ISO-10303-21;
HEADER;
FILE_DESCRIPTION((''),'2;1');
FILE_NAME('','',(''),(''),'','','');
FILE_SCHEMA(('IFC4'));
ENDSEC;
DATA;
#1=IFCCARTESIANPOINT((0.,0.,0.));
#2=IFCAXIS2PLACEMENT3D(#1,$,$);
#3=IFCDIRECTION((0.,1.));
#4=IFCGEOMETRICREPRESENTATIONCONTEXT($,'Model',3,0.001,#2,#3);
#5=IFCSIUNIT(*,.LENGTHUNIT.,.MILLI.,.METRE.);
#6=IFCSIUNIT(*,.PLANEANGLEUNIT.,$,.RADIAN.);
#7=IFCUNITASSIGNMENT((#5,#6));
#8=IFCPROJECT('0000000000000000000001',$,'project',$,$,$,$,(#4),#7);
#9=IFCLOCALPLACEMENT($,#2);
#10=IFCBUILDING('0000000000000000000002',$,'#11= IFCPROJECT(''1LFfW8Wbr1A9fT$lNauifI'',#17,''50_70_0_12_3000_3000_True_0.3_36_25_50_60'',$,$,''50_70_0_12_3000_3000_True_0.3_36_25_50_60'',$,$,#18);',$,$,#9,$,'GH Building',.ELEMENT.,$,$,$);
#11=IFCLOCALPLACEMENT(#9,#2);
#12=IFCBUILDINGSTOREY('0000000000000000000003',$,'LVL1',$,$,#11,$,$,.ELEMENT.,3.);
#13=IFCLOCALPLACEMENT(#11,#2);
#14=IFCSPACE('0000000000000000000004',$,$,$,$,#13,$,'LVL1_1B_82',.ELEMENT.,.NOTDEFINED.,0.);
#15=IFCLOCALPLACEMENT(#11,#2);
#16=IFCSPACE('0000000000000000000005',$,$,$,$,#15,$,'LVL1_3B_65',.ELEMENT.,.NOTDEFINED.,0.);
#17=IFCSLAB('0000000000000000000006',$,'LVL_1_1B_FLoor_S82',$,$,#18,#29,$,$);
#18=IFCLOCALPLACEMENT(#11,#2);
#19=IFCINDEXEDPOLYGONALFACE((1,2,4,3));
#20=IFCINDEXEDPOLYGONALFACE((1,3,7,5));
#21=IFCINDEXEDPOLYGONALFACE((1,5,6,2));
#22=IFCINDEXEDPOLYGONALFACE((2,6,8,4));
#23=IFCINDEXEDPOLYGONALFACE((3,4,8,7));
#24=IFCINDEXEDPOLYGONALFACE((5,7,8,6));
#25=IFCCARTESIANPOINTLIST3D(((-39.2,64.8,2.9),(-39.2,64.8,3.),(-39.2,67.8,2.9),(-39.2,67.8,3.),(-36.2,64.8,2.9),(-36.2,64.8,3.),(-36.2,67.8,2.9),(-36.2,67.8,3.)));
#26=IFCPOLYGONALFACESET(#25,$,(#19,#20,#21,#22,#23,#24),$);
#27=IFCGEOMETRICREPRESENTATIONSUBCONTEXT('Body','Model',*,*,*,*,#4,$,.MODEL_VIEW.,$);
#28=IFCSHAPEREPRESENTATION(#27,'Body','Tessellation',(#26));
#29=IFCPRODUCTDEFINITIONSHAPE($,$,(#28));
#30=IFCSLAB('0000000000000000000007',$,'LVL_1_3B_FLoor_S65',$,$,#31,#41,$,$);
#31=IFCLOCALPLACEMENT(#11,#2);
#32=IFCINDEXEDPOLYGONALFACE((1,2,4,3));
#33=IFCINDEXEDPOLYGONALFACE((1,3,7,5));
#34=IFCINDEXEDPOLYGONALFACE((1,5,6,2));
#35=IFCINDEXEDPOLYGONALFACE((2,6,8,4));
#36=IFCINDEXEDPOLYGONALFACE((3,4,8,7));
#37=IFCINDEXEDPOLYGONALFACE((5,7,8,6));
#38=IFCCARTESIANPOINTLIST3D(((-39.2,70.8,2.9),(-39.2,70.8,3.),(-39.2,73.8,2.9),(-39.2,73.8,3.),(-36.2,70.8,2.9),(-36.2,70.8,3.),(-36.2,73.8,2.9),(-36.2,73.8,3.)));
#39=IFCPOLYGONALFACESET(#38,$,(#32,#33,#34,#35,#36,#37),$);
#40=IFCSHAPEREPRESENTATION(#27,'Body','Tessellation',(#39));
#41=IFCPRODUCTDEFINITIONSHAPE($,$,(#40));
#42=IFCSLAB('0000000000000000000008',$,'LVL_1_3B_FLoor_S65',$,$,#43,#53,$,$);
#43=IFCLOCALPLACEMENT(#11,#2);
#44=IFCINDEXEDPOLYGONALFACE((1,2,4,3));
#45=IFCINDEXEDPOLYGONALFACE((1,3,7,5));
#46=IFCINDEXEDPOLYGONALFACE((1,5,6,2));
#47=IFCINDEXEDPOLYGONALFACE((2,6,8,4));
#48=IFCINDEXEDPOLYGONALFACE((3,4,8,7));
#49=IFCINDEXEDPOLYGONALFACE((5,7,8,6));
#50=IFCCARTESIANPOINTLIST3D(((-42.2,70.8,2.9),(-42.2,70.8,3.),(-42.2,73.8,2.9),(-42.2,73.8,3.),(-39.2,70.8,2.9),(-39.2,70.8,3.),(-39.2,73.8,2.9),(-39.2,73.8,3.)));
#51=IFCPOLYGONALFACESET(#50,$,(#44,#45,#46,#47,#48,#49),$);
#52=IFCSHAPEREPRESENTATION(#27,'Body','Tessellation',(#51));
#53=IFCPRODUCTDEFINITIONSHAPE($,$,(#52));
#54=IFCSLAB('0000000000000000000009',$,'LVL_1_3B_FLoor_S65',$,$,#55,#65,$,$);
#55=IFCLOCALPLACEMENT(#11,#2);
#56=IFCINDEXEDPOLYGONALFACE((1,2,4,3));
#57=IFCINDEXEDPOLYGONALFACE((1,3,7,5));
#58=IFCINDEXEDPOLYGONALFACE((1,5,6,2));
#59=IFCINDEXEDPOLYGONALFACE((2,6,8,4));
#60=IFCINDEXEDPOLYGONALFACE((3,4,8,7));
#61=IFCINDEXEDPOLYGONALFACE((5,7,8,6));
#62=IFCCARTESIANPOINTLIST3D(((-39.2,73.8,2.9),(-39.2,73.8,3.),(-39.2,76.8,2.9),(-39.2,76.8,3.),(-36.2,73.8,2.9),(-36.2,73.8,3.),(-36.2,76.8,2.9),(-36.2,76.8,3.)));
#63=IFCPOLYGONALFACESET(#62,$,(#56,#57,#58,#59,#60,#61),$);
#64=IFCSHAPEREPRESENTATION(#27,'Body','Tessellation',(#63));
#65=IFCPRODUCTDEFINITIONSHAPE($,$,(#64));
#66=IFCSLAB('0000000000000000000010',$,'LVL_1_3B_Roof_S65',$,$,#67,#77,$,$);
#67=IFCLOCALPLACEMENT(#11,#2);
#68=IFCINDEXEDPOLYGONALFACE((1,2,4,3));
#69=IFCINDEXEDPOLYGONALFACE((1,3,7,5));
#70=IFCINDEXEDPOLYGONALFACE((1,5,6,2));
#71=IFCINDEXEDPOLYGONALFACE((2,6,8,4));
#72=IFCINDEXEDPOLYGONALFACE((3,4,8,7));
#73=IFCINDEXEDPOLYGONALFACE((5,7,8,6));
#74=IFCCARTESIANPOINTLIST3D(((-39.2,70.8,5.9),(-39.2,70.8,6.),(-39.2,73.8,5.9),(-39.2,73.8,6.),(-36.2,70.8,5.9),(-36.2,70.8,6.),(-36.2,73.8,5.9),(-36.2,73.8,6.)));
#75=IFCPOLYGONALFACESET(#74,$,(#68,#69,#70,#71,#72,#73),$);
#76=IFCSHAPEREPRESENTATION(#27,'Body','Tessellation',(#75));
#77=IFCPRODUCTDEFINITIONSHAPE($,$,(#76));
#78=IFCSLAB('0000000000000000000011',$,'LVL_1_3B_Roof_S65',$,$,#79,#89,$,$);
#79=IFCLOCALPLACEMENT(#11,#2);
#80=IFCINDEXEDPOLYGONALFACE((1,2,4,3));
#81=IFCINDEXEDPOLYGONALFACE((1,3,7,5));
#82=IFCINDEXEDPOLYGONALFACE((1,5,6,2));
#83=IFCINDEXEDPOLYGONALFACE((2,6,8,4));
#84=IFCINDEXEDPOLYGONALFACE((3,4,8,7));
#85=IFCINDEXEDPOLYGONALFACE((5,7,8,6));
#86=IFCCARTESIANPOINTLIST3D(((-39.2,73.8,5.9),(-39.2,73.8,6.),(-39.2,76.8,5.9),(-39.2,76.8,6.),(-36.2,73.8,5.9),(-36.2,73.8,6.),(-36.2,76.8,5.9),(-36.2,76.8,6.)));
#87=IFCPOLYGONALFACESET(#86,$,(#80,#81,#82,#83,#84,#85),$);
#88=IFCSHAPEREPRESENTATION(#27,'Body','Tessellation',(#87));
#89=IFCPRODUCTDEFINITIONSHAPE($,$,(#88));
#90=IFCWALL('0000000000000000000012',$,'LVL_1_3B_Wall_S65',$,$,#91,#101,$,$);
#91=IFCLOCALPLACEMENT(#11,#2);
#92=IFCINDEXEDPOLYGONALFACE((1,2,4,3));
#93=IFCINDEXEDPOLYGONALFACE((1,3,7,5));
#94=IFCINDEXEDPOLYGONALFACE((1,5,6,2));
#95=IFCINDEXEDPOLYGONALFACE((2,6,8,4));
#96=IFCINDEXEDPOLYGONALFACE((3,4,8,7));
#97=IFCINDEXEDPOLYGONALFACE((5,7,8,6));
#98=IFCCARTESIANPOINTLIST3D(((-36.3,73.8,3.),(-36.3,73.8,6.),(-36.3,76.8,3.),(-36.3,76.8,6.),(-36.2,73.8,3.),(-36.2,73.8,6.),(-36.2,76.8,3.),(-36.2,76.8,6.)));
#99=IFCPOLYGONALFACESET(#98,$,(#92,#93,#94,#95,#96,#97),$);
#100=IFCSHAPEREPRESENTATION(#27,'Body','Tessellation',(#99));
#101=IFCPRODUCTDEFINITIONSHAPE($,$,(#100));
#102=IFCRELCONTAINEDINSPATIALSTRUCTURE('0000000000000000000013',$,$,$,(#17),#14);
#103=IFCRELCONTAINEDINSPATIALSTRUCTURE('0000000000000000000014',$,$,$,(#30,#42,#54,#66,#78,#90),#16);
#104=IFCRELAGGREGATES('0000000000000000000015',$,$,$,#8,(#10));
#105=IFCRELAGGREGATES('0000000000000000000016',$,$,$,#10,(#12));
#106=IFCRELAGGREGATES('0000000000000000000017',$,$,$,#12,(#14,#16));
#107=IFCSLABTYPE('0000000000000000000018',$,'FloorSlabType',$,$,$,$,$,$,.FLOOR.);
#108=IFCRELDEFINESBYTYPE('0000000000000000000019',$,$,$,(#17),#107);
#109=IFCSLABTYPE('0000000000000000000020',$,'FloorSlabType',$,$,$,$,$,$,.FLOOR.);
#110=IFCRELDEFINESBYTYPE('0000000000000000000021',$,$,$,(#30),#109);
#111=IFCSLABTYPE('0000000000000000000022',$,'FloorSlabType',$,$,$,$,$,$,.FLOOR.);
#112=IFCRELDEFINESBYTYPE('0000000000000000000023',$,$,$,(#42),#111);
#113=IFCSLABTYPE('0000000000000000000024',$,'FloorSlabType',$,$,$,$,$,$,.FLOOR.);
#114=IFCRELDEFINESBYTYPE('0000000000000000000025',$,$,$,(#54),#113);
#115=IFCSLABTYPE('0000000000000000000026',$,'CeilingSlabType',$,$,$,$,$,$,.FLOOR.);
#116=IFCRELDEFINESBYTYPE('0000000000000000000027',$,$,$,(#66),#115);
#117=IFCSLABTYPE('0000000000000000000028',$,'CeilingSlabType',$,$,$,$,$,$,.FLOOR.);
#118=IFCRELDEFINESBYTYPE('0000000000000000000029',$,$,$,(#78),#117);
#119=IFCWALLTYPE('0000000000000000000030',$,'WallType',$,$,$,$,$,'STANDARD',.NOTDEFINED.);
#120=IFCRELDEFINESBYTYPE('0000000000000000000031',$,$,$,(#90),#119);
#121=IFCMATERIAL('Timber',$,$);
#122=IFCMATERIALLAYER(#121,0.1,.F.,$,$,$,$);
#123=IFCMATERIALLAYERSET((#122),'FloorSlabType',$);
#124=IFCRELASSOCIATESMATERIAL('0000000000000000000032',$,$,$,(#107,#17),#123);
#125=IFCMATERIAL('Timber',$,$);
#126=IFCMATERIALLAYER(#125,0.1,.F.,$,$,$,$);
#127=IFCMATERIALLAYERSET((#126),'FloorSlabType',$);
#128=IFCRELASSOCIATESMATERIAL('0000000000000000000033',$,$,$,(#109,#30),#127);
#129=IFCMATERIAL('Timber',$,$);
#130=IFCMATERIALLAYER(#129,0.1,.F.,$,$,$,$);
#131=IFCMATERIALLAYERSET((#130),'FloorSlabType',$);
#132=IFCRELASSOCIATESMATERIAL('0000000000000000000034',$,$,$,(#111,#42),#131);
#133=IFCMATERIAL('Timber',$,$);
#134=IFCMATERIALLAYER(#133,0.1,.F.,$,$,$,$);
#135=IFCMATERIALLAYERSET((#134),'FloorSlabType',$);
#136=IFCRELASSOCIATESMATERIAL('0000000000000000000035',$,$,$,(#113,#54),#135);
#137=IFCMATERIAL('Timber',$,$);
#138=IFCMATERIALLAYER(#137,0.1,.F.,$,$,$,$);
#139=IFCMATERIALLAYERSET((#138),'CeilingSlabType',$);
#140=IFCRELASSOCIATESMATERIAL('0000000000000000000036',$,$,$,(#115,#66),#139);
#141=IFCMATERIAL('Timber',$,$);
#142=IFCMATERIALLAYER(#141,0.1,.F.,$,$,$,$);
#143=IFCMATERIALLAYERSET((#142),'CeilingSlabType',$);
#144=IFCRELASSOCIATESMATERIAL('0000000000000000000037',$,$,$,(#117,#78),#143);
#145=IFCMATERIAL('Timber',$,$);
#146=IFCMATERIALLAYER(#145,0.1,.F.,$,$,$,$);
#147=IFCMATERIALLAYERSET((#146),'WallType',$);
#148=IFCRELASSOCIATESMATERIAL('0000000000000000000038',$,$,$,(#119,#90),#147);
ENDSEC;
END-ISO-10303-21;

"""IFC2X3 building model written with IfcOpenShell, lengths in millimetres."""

from ifc_helpers import new_model, si_unit, direction, frame, frame_2d, origin, place, context, subcontext, project, spatial, rectangle, extrude, material, layer, layer_set, layer_usage, type_object, element, save


model = new_model("IFC2X3")

# Units and contexts
model_context = context("Model", 3, precision=0.001, world=origin(), true_north=direction((0.0, 1.0)))
body_context = subcontext(model_context, "Body", "Model", "MODEL_VIEW")
ifc_project = project(units=[si_unit("LENGTHUNIT", "METRE", prefix="MILLI"), si_unit("PLANEANGLEUNIT", "RADIAN")], contexts=[model_context])

# Building, storey
building_placement = place(None, origin())
building = spatial("IfcBuilding", under=ifc_project, at=building_placement, Name="#11= IFCPROJECT('1LFfW8Wbr1A9fT$lNauifI',#17,'50_70_0_12_3000_3000_True_0.3_36_25_50_60',$,$,'50_70_0_12_3000_3000_True_0.3_36_25_50_60',$,$,#18);", LongName="GH Building", CompositionType="ELEMENT")
storey_placement = place(building_placement, origin())
storey = spatial("IfcBuildingStorey", under=building, at=storey_placement, Name="LVL1", CompositionType="ELEMENT", Elevation=3.0)

# Shared definitions
space_1_placement = place(storey_placement, origin())
space_1 = spatial("IfcSpace", under=storey, at=space_1_placement, LongName="LVL1_1B_82", CompositionType="ELEMENT", InteriorOrExteriorSpace="NOTDEFINED", ElevationWithFlooring=0.0)

# Slab
ifc_material_1 = material(Name="Timber")
ifc_layer_1 = layer(ifc_material_1, 0.1, ventilated=False)
ifc_layer_set_1 = layer_set([ifc_layer_1], Name="FloorSlabType")
ifc_layer_usage_1 = layer_usage(ifc_layer_set_1, "AXIS3", "NEGATIVE", -0.1)
slab_type_1 = type_object("IfcSlabType", Name="FloorSlabType", PredefinedType="FLOOR", material=ifc_layer_set_1)
slab_1_placement = place(space_1_placement, frame((-36.2, 67.8, 2.9), z_axis=(0.0, 0.0, 1.0), x_axis=(-1.0, 0.0, 0.0)))
element("IfcSlab", 1, at=slab_1_placement, inside=space_1, type_object=slab_type_1, material=ifc_layer_usage_1, Name="LVL_1_1B_FLoor_S82", context=body_context, shape_type="SweptSolid", body=[
    extrude(rectangle(XDim=3.0, YDim=3.0, at=frame_2d((1.5, 1.5))), origin(), (0.0, 0.0, 1.0), 0.1),
])

# Shared definitions
space_2_placement = place(storey_placement, origin())
space_2 = spatial("IfcSpace", under=storey, at=space_2_placement, LongName="LVL1_3B_65", CompositionType="ELEMENT", InteriorOrExteriorSpace="NOTDEFINED", ElevationWithFlooring=0.0)

# Slabs
ifc_material_2 = material(Name="Timber")
ifc_layer_2 = layer(ifc_material_2, 0.1, ventilated=False)
ifc_layer_set_2 = layer_set([ifc_layer_2], Name="FloorSlabType")
ifc_layer_usage_2 = layer_usage(ifc_layer_set_2, "AXIS3", "NEGATIVE", -0.1)
slab_type_2 = type_object("IfcSlabType", Name="FloorSlabType", PredefinedType="FLOOR", material=ifc_layer_set_2)
slab_2_placement = place(space_2_placement, frame((-36.2, 73.8, 2.9), z_axis=(0.0, 0.0, 1.0), x_axis=(-1.0, 0.0, 0.0)))
element("IfcSlab", 2, at=slab_2_placement, inside=space_2, type_object=slab_type_2, material=ifc_layer_usage_2, Name="LVL_1_3B_FLoor_S65", context=body_context, shape_type="SweptSolid", body=[
    extrude(rectangle(XDim=3.0, YDim=3.0, at=frame_2d((1.5, 1.5))), origin(), (0.0, 0.0, 1.0), 0.1),
])
ifc_material_3 = material(Name="Timber")
ifc_layer_3 = layer(ifc_material_3, 0.1, ventilated=False)
ifc_layer_set_3 = layer_set([ifc_layer_3], Name="FloorSlabType")
ifc_layer_usage_3 = layer_usage(ifc_layer_set_3, "AXIS3", "NEGATIVE", -0.1)
slab_type_3 = type_object("IfcSlabType", Name="FloorSlabType", PredefinedType="FLOOR", material=ifc_layer_set_3)
slab_3_placement = place(space_2_placement, frame((-39.2, 73.8, 2.9), z_axis=(0.0, 0.0, 1.0), x_axis=(-1.0, 0.0, 0.0)))
element("IfcSlab", 3, at=slab_3_placement, inside=space_2, type_object=slab_type_3, material=ifc_layer_usage_3, Name="LVL_1_3B_FLoor_S65", context=body_context, shape_type="SweptSolid", body=[
    extrude(rectangle(XDim=3.0, YDim=3.0, at=frame_2d((1.5, 1.5))), origin(), (0.0, 0.0, 1.0), 0.1),
])
ifc_material_4 = material(Name="Timber")
ifc_layer_4 = layer(ifc_material_4, 0.1, ventilated=False)
ifc_layer_set_4 = layer_set([ifc_layer_4], Name="FloorSlabType")
ifc_layer_usage_4 = layer_usage(ifc_layer_set_4, "AXIS3", "NEGATIVE", -0.1)
slab_type_4 = type_object("IfcSlabType", Name="FloorSlabType", PredefinedType="FLOOR", material=ifc_layer_set_4)
slab_4_placement = place(space_2_placement, frame((-36.2, 76.8, 2.9), z_axis=(0.0, 0.0, 1.0), x_axis=(-1.0, 0.0, 0.0)))
element("IfcSlab", 4, at=slab_4_placement, inside=space_2, type_object=slab_type_4, material=ifc_layer_usage_4, Name="LVL_1_3B_FLoor_S65", context=body_context, shape_type="SweptSolid", body=[
    extrude(rectangle(XDim=3.0, YDim=3.0, at=frame_2d((1.5, 1.5))), origin(), (0.0, 0.0, 1.0), 0.1),
])
ifc_material_5 = material(Name="Timber")
ifc_layer_5 = layer(ifc_material_5, 0.1, ventilated=False)
ifc_layer_set_5 = layer_set([ifc_layer_5], Name="CeilingSlabType")
ifc_layer_usage_5 = layer_usage(ifc_layer_set_5, "AXIS3", "NEGATIVE", -0.1)
slab_type_5 = type_object("IfcSlabType", Name="CeilingSlabType", PredefinedType="FLOOR", material=ifc_layer_set_5)
slab_5_placement = place(space_2_placement, frame((-36.2, 73.8, 5.9), z_axis=(0.0, 0.0, 1.0), x_axis=(-1.0, 0.0, 0.0)))
element("IfcSlab", 5, at=slab_5_placement, inside=space_2, type_object=slab_type_5, material=ifc_layer_usage_5, Name="LVL_1_3B_Roof_S65", context=body_context, shape_type="SweptSolid", body=[
    extrude(rectangle(XDim=3.0, YDim=3.0, at=frame_2d((1.5, 1.5))), origin(), (0.0, 0.0, 1.0), 0.1),
])
ifc_material_6 = material(Name="Timber")
ifc_layer_6 = layer(ifc_material_6, 0.1, ventilated=False)
ifc_layer_set_6 = layer_set([ifc_layer_6], Name="CeilingSlabType")
ifc_layer_usage_6 = layer_usage(ifc_layer_set_6, "AXIS3", "NEGATIVE", -0.1)
slab_type_6 = type_object("IfcSlabType", Name="CeilingSlabType", PredefinedType="FLOOR", material=ifc_layer_set_6)
slab_6_placement = place(space_2_placement, frame((-36.2, 76.8, 5.9), z_axis=(0.0, 0.0, 1.0), x_axis=(-1.0, 0.0, 0.0)))
element("IfcSlab", 6, at=slab_6_placement, inside=space_2, type_object=slab_type_6, material=ifc_layer_usage_6, Name="LVL_1_3B_Roof_S65", context=body_context, shape_type="SweptSolid", body=[
    extrude(rectangle(XDim=3.0, YDim=3.0, at=frame_2d((1.5, 1.5))), origin(), (0.0, 0.0, 1.0), 0.1),
])

# Wall
ifc_material_7 = material(Name="Timber")
ifc_layer_7 = layer(ifc_material_7, 0.1, ventilated=False)
ifc_layer_set_7 = layer_set([ifc_layer_7], Name="WallType")
ifc_layer_usage_7 = layer_usage(ifc_layer_set_7, "AXIS2", "NEGATIVE", 0.0)
wall_type_1 = type_object("IfcWallType", Name="WallType", ElementType="STANDARD", PredefinedType="NOTDEFINED", material=ifc_layer_set_7)
wall_1_placement = place(space_2_placement, frame((-36.2, 76.8, 3.0), z_axis=(0.0, 0.0, 1.0), x_axis=(0.0, -1.0, 0.0)))
element("IfcWall", 7, at=wall_1_placement, inside=space_2, type_object=wall_type_1, material=ifc_layer_usage_7, Name="LVL_1_3B_Wall_S65", context=body_context, shape_type="SweptSolid", body=[
    extrude(rectangle(XDim=3.0, YDim=0.1, at=frame_2d((1.5, -0.1))), origin(), (0.0, 0.0, 1.0), 3.0),
])

save(model, "model.ifc")
